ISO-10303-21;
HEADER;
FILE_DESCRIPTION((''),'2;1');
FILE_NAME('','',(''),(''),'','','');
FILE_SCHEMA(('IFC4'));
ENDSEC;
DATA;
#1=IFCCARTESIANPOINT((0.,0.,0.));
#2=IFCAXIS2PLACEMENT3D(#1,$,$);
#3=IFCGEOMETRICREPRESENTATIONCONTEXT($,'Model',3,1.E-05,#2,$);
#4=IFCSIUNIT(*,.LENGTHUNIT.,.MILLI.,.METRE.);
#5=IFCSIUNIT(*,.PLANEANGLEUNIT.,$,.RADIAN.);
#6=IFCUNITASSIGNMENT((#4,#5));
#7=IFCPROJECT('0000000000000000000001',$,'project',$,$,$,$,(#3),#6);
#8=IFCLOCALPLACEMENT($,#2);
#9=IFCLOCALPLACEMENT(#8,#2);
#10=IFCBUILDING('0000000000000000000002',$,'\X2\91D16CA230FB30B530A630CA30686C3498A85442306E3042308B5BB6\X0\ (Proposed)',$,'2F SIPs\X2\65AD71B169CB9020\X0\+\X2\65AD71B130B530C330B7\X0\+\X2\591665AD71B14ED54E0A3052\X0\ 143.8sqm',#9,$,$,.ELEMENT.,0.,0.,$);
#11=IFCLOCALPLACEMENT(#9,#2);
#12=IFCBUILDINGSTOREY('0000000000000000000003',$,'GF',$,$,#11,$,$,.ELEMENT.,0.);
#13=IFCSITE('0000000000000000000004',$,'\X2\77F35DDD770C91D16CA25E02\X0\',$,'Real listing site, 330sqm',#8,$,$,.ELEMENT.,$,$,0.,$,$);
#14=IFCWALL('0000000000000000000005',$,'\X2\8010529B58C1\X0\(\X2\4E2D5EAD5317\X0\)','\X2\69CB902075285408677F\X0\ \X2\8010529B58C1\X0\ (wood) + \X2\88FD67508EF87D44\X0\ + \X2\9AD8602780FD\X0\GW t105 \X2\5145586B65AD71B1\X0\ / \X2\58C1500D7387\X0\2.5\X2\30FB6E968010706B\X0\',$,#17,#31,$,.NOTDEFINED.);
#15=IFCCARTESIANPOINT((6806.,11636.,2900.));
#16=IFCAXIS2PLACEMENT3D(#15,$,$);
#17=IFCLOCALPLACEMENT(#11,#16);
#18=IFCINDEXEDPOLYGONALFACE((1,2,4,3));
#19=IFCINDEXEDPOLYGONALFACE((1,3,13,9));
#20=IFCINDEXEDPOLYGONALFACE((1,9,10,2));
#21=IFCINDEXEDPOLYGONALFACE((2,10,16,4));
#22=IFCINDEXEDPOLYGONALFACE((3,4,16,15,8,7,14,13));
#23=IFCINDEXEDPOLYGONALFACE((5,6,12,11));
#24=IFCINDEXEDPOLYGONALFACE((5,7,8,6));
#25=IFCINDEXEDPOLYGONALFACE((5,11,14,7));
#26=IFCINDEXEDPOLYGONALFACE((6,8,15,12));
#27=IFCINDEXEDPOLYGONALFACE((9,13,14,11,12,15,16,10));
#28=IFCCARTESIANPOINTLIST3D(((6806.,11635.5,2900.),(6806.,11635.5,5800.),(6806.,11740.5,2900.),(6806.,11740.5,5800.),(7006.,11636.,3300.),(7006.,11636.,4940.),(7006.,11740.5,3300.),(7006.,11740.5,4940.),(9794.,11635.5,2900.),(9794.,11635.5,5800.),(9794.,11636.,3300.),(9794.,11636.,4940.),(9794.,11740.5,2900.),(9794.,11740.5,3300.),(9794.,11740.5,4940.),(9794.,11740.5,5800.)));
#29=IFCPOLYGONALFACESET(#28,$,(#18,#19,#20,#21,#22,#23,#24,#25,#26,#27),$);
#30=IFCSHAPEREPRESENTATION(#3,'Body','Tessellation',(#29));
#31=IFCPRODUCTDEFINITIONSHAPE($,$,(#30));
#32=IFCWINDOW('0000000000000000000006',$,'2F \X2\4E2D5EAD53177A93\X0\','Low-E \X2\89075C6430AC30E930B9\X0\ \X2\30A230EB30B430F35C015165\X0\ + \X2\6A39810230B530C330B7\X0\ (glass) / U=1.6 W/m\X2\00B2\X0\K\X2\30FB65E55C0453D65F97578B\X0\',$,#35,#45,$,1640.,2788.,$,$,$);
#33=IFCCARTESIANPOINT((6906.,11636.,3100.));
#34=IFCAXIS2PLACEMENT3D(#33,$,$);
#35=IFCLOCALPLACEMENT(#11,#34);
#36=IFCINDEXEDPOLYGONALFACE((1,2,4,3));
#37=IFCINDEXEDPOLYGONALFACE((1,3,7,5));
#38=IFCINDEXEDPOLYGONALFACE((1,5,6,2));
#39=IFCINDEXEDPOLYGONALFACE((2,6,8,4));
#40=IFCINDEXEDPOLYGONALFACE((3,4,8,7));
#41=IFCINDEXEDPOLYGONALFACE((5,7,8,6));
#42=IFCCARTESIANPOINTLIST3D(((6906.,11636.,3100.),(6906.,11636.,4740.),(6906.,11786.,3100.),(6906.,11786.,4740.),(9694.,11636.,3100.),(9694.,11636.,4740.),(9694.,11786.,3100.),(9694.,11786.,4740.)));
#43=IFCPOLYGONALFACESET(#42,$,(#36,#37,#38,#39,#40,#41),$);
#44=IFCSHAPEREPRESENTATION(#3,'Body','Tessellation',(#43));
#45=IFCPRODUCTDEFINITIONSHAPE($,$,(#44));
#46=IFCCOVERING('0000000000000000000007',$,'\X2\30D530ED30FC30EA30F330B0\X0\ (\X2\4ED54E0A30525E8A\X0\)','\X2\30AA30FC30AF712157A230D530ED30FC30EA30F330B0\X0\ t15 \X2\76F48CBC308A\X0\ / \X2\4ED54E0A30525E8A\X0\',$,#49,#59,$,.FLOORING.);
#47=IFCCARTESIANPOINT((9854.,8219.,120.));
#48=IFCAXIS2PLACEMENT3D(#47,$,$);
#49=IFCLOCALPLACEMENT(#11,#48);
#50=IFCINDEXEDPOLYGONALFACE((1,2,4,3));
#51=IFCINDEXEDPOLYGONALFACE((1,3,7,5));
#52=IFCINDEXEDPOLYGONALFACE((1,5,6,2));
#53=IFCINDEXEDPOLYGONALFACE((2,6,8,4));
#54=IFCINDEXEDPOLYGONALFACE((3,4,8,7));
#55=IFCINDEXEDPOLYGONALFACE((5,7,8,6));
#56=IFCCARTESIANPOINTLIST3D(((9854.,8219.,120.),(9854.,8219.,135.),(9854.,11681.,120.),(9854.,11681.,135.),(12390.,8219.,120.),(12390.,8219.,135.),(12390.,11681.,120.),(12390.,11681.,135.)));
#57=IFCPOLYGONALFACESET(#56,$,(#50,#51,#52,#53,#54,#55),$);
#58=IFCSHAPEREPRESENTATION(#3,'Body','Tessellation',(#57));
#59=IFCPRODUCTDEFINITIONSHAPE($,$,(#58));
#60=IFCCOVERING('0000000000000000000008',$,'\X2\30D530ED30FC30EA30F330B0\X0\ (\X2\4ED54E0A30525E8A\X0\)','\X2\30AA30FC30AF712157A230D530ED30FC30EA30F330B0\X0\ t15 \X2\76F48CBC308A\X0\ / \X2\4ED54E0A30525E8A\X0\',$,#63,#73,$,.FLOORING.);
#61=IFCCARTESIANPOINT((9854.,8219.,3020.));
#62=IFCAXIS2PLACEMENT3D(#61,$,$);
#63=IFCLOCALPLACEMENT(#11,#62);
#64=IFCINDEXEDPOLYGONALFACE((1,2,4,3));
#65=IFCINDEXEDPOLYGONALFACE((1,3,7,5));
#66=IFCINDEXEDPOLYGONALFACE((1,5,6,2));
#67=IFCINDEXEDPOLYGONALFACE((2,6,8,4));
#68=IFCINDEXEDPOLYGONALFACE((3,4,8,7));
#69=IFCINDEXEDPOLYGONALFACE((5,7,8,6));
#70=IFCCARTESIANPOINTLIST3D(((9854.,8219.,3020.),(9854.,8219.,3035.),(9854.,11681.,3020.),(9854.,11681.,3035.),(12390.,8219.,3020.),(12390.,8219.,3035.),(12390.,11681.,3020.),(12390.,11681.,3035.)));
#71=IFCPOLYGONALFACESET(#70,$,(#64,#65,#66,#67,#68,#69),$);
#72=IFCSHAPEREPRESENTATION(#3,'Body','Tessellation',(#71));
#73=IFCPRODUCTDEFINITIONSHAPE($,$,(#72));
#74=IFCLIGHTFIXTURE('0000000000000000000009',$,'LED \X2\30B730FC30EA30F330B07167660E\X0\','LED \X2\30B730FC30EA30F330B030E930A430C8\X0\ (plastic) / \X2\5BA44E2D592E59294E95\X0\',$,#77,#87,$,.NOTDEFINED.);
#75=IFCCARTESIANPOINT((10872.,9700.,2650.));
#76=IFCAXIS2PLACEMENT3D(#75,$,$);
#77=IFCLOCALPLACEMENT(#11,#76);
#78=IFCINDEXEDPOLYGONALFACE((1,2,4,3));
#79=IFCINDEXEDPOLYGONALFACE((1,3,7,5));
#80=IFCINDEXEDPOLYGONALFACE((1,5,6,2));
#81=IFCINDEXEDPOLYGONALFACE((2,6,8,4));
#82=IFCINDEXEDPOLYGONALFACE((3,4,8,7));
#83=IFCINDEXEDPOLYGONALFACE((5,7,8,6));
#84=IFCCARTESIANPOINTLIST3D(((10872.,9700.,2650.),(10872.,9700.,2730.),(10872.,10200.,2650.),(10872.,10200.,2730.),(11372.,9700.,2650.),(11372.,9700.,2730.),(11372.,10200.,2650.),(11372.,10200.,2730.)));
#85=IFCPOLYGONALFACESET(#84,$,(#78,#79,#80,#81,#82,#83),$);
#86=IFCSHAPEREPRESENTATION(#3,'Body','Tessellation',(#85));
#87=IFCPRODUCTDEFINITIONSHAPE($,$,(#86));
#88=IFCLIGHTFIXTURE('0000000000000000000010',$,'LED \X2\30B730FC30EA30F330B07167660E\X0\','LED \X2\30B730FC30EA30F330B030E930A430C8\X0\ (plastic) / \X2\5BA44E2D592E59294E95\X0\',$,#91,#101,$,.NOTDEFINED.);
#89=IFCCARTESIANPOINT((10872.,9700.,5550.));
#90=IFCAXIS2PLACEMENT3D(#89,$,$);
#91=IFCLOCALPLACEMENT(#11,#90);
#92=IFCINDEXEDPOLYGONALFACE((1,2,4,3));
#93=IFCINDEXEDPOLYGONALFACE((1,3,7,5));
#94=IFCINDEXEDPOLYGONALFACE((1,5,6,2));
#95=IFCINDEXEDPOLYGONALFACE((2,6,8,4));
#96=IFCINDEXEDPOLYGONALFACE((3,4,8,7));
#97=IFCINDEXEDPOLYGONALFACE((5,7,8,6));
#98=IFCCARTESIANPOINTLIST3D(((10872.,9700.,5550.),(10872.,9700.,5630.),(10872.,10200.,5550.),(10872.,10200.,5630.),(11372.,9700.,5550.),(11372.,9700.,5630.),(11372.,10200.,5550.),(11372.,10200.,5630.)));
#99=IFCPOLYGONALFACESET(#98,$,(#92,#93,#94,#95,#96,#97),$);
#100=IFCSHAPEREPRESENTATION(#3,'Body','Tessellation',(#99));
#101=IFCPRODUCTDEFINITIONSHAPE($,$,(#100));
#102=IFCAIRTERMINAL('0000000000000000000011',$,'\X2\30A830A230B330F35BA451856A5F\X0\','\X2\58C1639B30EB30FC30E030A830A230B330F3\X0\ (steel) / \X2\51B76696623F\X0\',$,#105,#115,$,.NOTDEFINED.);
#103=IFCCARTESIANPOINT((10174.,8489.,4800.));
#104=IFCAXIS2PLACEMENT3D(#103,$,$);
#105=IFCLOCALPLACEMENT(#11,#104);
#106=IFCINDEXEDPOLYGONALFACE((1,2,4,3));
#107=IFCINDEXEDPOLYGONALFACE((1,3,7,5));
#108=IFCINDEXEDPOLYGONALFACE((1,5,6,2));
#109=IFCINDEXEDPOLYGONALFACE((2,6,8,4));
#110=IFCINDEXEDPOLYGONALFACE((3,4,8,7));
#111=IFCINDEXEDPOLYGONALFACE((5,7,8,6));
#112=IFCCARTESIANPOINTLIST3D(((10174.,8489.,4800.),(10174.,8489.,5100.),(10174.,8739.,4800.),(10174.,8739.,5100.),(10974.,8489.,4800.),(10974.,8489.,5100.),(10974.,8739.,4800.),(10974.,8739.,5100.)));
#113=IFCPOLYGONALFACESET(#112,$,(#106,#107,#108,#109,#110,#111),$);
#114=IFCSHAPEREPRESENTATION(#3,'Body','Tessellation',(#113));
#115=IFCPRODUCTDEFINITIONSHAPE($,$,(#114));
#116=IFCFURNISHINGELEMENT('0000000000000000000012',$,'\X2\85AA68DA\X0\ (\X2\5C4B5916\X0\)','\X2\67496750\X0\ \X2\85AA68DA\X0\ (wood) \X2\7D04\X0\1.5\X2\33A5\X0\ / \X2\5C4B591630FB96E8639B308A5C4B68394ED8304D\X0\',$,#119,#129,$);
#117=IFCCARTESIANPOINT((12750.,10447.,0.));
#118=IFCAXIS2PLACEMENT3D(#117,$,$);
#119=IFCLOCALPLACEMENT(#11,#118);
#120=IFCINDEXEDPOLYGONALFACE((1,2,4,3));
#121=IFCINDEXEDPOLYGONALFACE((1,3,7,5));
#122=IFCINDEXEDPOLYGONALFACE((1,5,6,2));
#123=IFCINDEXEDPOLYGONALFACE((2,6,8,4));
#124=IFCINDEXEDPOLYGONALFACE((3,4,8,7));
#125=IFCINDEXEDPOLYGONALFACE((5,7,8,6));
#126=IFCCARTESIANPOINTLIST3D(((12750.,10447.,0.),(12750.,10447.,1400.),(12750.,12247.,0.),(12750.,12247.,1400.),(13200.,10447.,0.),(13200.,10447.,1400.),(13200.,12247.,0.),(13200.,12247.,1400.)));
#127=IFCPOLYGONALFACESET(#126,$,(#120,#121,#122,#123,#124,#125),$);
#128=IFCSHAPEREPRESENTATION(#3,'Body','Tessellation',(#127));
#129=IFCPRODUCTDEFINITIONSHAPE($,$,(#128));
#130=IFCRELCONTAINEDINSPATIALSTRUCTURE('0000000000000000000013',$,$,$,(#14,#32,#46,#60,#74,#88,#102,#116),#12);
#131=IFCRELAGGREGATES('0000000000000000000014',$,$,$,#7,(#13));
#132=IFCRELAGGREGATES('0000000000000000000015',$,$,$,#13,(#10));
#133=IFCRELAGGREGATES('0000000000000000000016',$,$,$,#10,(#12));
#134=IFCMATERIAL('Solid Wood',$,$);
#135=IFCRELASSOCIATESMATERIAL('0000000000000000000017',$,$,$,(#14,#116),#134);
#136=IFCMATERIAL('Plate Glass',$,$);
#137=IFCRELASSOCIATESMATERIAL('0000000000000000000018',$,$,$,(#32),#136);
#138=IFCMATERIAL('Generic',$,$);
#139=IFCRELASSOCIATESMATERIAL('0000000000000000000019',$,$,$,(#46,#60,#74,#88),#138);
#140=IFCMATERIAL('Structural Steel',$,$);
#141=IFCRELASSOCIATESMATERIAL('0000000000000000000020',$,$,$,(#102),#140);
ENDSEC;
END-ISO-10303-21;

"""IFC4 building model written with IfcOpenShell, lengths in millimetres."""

from ifc_helpers import new_model, si_unit, frame, frame_2d, origin, place, context, project, spatial, rectangle, extrude, material, element, fill, save


model = new_model("IFC4")

# Units and contexts
model_context = context("Model", 3, precision=1e-05, world=origin())
ifc_project = project(units=[si_unit("LENGTHUNIT", "METRE", prefix="MILLI"), si_unit("PLANEANGLEUNIT", "RADIAN")], contexts=[model_context])

# Site, building, storey
site_placement = place(None, origin())
site = spatial("IfcSite", under=ifc_project, at=site_placement, Name="石川県金沢市", ObjectType="Real listing site, 330sqm", CompositionType="ELEMENT", RefElevation=0.0)
building_placement = place(site_placement, origin())
building = spatial("IfcBuilding", under=site, at=building_placement, Name="金沢・サウナと水風呂のある家 (Proposed)", ObjectType="2F SIPs断熱構造+断熱サッシ+外断熱仕上げ 143.8sqm", CompositionType="ELEMENT", ElevationOfRefHeight=0.0, ElevationOfTerrain=0.0)
storey_placement = place(building_placement, origin())
storey = spatial("IfcBuildingStorey", under=building, at=storey_placement, Name="GF", CompositionType="ELEMENT", Elevation=0.0)

# Shared definitions
ifc_material_1 = material(Name="Solid Wood")

# Wall, opening, window
ifc_material_2 = material(Name="Plate Glass")
wall_1_placement = place(storey_placement, frame((6806.0, 11636.0, 2900.0)))
wall_1 = element("IfcWall", 1, at=wall_1_placement, inside=storey, material=ifc_material_1, Name="耐力壁(中庭北)", Description="構造用合板 耐力壁 (wood) + 製材軸組 + 高性能GW t105 充填断熱 / 壁倍率2.5・準耐火", PredefinedType="NOTDEFINED", context=model_context, shape_type="SweptSolid", body=[
    extrude(rectangle(XDim=2988.0, YDim=105.0, at=frame_2d((1494.0, 52.0))), frame((6806.0, 11636.0, 2900.0)), (0.0, 0.0, 1.0), 2900.0),
])
opening_1_placement = place(storey_placement, frame((6906.0, 11636.0, 3100.0)))
opening_1 = element("IfcOpeningElement", 2, at=opening_1_placement, cuts=wall_1, PredefinedType="NOTDEFINED", context=model_context, shape_type="SweptSolid", body=[
    extrude(rectangle(XDim=2788.0, YDim=150.0, at=frame_2d((1394.0, 75.0))), frame((6906.0, 11636.0, 3100.0)), (0.0, 0.0, 1.0), 1640.0),
])
window_1_placement = place(storey_placement, frame((6906.0, 11636.0, 3100.0)))
window_1 = element("IfcWindow", 3, at=window_1_placement, inside=storey, material=ifc_material_2, Name="2F 中庭北窓", Description="Low-E 複層ガラス アルゴン封入 + 樹脂サッシ (glass) / U=1.6 W/m²K・日射取得型", OverallHeight=1640.0, OverallWidth=2788.0, context=model_context, shape_type="SweptSolid", body=[
    extrude(rectangle(XDim=2788.0, YDim=150.0, at=frame_2d((1394.0, 75.0))), frame((6906.0, 11636.0, 3100.0)), (0.0, 0.0, 1.0), 1640.0),
])
fill(opening_1, window_1)

# Coverings
ifc_material_3 = material(Name="Generic")
covering_1_placement = place(storey_placement, frame((9854.0, 8219.0, 120.0)))
element("IfcCovering", 4, at=covering_1_placement, inside=storey, material=ifc_material_3, Name="フローリング (仕上げ床)", Description="オーク無垢フローリング t15 直貼り / 仕上げ床", PredefinedType="FLOORING", context=model_context, shape_type="SweptSolid", body=[
    extrude(rectangle(XDim=2536.0, YDim=3462.0, at=frame_2d((1268.0, 1731.0))), frame((9854.0, 8219.0, 120.0)), (0.0, 0.0, 1.0), 15.0),
])
covering_2_placement = place(storey_placement, frame((9854.0, 8219.0, 3020.0)))
element("IfcCovering", 5, at=covering_2_placement, inside=storey, material=ifc_material_3, Name="フローリング (仕上げ床)", Description="オーク無垢フローリング t15 直貼り / 仕上げ床", PredefinedType="FLOORING", context=model_context, shape_type="SweptSolid", body=[
    extrude(rectangle(XDim=2536.0, YDim=3462.0, at=frame_2d((1268.0, 1731.0))), frame((9854.0, 8219.0, 3020.0)), (0.0, 0.0, 1.0), 15.0),
])

# Light fixtures
light_fixture_1_placement = place(storey_placement, frame((10872.0, 9700.0, 2650.0)))
element("IfcLightFixture", 6, at=light_fixture_1_placement, inside=storey, material=ifc_material_3, Name="LED シーリング照明", Description="LED シーリングライト (plastic) / 室中央天井", PredefinedType="NOTDEFINED", context=model_context, shape_type="SweptSolid", body=[
    extrude(rectangle(XDim=500.0, YDim=500.0, at=frame_2d((250.0, 250.0))), frame((10872.0, 9700.0, 2650.0)), (0.0, 0.0, 1.0), 80.0),
])
light_fixture_2_placement = place(storey_placement, frame((10872.0, 9700.0, 5550.0)))
element("IfcLightFixture", 7, at=light_fixture_2_placement, inside=storey, material=ifc_material_3, Name="LED シーリング照明", Description="LED シーリングライト (plastic) / 室中央天井", PredefinedType="NOTDEFINED", context=model_context, shape_type="SweptSolid", body=[
    extrude(rectangle(XDim=500.0, YDim=500.0, at=frame_2d((250.0, 250.0))), frame((10872.0, 9700.0, 5550.0)), (0.0, 0.0, 1.0), 80.0),
])

# Air terminal
ifc_material_4 = material(Name="Structural Steel")
air_terminal_placement = place(storey_placement, frame((10174.0, 8489.0, 4800.0)))
element("IfcAirTerminal", 8, at=air_terminal_placement, inside=storey, material=ifc_material_4, Name="エアコン室内機", Description="壁掛ルームエアコン (steel) / 冷暖房", PredefinedType="NOTDEFINED", context=model_context, shape_type="SweptSolid", body=[
    extrude(rectangle(XDim=800.0, YDim=250.0, at=frame_2d((400.0, 125.0))), frame((10174.0, 8489.0, 4800.0)), (0.0, 0.0, 1.0), 300.0),
])

# Furnishing element
furnishing_placement = place(storey_placement, frame((12750.0, 10447.0, 0.0)))
element("IfcFurnishingElement", 9, at=furnishing_placement, inside=storey, material=ifc_material_1, Name="薪棚 (屋外)", Description="杉材 薪棚 (wood) 約1.5㎥ / 屋外・雨掛り屋根付き", context=model_context, shape_type="SweptSolid", body=[
    extrude(rectangle(XDim=450.0, YDim=1800.0, at=frame_2d((225.0, 900.0))), frame((12750.0, 10447.0, 0.0)), (0.0, 0.0, 1.0), 1400.0),
])

save(model, "model.ifc")
